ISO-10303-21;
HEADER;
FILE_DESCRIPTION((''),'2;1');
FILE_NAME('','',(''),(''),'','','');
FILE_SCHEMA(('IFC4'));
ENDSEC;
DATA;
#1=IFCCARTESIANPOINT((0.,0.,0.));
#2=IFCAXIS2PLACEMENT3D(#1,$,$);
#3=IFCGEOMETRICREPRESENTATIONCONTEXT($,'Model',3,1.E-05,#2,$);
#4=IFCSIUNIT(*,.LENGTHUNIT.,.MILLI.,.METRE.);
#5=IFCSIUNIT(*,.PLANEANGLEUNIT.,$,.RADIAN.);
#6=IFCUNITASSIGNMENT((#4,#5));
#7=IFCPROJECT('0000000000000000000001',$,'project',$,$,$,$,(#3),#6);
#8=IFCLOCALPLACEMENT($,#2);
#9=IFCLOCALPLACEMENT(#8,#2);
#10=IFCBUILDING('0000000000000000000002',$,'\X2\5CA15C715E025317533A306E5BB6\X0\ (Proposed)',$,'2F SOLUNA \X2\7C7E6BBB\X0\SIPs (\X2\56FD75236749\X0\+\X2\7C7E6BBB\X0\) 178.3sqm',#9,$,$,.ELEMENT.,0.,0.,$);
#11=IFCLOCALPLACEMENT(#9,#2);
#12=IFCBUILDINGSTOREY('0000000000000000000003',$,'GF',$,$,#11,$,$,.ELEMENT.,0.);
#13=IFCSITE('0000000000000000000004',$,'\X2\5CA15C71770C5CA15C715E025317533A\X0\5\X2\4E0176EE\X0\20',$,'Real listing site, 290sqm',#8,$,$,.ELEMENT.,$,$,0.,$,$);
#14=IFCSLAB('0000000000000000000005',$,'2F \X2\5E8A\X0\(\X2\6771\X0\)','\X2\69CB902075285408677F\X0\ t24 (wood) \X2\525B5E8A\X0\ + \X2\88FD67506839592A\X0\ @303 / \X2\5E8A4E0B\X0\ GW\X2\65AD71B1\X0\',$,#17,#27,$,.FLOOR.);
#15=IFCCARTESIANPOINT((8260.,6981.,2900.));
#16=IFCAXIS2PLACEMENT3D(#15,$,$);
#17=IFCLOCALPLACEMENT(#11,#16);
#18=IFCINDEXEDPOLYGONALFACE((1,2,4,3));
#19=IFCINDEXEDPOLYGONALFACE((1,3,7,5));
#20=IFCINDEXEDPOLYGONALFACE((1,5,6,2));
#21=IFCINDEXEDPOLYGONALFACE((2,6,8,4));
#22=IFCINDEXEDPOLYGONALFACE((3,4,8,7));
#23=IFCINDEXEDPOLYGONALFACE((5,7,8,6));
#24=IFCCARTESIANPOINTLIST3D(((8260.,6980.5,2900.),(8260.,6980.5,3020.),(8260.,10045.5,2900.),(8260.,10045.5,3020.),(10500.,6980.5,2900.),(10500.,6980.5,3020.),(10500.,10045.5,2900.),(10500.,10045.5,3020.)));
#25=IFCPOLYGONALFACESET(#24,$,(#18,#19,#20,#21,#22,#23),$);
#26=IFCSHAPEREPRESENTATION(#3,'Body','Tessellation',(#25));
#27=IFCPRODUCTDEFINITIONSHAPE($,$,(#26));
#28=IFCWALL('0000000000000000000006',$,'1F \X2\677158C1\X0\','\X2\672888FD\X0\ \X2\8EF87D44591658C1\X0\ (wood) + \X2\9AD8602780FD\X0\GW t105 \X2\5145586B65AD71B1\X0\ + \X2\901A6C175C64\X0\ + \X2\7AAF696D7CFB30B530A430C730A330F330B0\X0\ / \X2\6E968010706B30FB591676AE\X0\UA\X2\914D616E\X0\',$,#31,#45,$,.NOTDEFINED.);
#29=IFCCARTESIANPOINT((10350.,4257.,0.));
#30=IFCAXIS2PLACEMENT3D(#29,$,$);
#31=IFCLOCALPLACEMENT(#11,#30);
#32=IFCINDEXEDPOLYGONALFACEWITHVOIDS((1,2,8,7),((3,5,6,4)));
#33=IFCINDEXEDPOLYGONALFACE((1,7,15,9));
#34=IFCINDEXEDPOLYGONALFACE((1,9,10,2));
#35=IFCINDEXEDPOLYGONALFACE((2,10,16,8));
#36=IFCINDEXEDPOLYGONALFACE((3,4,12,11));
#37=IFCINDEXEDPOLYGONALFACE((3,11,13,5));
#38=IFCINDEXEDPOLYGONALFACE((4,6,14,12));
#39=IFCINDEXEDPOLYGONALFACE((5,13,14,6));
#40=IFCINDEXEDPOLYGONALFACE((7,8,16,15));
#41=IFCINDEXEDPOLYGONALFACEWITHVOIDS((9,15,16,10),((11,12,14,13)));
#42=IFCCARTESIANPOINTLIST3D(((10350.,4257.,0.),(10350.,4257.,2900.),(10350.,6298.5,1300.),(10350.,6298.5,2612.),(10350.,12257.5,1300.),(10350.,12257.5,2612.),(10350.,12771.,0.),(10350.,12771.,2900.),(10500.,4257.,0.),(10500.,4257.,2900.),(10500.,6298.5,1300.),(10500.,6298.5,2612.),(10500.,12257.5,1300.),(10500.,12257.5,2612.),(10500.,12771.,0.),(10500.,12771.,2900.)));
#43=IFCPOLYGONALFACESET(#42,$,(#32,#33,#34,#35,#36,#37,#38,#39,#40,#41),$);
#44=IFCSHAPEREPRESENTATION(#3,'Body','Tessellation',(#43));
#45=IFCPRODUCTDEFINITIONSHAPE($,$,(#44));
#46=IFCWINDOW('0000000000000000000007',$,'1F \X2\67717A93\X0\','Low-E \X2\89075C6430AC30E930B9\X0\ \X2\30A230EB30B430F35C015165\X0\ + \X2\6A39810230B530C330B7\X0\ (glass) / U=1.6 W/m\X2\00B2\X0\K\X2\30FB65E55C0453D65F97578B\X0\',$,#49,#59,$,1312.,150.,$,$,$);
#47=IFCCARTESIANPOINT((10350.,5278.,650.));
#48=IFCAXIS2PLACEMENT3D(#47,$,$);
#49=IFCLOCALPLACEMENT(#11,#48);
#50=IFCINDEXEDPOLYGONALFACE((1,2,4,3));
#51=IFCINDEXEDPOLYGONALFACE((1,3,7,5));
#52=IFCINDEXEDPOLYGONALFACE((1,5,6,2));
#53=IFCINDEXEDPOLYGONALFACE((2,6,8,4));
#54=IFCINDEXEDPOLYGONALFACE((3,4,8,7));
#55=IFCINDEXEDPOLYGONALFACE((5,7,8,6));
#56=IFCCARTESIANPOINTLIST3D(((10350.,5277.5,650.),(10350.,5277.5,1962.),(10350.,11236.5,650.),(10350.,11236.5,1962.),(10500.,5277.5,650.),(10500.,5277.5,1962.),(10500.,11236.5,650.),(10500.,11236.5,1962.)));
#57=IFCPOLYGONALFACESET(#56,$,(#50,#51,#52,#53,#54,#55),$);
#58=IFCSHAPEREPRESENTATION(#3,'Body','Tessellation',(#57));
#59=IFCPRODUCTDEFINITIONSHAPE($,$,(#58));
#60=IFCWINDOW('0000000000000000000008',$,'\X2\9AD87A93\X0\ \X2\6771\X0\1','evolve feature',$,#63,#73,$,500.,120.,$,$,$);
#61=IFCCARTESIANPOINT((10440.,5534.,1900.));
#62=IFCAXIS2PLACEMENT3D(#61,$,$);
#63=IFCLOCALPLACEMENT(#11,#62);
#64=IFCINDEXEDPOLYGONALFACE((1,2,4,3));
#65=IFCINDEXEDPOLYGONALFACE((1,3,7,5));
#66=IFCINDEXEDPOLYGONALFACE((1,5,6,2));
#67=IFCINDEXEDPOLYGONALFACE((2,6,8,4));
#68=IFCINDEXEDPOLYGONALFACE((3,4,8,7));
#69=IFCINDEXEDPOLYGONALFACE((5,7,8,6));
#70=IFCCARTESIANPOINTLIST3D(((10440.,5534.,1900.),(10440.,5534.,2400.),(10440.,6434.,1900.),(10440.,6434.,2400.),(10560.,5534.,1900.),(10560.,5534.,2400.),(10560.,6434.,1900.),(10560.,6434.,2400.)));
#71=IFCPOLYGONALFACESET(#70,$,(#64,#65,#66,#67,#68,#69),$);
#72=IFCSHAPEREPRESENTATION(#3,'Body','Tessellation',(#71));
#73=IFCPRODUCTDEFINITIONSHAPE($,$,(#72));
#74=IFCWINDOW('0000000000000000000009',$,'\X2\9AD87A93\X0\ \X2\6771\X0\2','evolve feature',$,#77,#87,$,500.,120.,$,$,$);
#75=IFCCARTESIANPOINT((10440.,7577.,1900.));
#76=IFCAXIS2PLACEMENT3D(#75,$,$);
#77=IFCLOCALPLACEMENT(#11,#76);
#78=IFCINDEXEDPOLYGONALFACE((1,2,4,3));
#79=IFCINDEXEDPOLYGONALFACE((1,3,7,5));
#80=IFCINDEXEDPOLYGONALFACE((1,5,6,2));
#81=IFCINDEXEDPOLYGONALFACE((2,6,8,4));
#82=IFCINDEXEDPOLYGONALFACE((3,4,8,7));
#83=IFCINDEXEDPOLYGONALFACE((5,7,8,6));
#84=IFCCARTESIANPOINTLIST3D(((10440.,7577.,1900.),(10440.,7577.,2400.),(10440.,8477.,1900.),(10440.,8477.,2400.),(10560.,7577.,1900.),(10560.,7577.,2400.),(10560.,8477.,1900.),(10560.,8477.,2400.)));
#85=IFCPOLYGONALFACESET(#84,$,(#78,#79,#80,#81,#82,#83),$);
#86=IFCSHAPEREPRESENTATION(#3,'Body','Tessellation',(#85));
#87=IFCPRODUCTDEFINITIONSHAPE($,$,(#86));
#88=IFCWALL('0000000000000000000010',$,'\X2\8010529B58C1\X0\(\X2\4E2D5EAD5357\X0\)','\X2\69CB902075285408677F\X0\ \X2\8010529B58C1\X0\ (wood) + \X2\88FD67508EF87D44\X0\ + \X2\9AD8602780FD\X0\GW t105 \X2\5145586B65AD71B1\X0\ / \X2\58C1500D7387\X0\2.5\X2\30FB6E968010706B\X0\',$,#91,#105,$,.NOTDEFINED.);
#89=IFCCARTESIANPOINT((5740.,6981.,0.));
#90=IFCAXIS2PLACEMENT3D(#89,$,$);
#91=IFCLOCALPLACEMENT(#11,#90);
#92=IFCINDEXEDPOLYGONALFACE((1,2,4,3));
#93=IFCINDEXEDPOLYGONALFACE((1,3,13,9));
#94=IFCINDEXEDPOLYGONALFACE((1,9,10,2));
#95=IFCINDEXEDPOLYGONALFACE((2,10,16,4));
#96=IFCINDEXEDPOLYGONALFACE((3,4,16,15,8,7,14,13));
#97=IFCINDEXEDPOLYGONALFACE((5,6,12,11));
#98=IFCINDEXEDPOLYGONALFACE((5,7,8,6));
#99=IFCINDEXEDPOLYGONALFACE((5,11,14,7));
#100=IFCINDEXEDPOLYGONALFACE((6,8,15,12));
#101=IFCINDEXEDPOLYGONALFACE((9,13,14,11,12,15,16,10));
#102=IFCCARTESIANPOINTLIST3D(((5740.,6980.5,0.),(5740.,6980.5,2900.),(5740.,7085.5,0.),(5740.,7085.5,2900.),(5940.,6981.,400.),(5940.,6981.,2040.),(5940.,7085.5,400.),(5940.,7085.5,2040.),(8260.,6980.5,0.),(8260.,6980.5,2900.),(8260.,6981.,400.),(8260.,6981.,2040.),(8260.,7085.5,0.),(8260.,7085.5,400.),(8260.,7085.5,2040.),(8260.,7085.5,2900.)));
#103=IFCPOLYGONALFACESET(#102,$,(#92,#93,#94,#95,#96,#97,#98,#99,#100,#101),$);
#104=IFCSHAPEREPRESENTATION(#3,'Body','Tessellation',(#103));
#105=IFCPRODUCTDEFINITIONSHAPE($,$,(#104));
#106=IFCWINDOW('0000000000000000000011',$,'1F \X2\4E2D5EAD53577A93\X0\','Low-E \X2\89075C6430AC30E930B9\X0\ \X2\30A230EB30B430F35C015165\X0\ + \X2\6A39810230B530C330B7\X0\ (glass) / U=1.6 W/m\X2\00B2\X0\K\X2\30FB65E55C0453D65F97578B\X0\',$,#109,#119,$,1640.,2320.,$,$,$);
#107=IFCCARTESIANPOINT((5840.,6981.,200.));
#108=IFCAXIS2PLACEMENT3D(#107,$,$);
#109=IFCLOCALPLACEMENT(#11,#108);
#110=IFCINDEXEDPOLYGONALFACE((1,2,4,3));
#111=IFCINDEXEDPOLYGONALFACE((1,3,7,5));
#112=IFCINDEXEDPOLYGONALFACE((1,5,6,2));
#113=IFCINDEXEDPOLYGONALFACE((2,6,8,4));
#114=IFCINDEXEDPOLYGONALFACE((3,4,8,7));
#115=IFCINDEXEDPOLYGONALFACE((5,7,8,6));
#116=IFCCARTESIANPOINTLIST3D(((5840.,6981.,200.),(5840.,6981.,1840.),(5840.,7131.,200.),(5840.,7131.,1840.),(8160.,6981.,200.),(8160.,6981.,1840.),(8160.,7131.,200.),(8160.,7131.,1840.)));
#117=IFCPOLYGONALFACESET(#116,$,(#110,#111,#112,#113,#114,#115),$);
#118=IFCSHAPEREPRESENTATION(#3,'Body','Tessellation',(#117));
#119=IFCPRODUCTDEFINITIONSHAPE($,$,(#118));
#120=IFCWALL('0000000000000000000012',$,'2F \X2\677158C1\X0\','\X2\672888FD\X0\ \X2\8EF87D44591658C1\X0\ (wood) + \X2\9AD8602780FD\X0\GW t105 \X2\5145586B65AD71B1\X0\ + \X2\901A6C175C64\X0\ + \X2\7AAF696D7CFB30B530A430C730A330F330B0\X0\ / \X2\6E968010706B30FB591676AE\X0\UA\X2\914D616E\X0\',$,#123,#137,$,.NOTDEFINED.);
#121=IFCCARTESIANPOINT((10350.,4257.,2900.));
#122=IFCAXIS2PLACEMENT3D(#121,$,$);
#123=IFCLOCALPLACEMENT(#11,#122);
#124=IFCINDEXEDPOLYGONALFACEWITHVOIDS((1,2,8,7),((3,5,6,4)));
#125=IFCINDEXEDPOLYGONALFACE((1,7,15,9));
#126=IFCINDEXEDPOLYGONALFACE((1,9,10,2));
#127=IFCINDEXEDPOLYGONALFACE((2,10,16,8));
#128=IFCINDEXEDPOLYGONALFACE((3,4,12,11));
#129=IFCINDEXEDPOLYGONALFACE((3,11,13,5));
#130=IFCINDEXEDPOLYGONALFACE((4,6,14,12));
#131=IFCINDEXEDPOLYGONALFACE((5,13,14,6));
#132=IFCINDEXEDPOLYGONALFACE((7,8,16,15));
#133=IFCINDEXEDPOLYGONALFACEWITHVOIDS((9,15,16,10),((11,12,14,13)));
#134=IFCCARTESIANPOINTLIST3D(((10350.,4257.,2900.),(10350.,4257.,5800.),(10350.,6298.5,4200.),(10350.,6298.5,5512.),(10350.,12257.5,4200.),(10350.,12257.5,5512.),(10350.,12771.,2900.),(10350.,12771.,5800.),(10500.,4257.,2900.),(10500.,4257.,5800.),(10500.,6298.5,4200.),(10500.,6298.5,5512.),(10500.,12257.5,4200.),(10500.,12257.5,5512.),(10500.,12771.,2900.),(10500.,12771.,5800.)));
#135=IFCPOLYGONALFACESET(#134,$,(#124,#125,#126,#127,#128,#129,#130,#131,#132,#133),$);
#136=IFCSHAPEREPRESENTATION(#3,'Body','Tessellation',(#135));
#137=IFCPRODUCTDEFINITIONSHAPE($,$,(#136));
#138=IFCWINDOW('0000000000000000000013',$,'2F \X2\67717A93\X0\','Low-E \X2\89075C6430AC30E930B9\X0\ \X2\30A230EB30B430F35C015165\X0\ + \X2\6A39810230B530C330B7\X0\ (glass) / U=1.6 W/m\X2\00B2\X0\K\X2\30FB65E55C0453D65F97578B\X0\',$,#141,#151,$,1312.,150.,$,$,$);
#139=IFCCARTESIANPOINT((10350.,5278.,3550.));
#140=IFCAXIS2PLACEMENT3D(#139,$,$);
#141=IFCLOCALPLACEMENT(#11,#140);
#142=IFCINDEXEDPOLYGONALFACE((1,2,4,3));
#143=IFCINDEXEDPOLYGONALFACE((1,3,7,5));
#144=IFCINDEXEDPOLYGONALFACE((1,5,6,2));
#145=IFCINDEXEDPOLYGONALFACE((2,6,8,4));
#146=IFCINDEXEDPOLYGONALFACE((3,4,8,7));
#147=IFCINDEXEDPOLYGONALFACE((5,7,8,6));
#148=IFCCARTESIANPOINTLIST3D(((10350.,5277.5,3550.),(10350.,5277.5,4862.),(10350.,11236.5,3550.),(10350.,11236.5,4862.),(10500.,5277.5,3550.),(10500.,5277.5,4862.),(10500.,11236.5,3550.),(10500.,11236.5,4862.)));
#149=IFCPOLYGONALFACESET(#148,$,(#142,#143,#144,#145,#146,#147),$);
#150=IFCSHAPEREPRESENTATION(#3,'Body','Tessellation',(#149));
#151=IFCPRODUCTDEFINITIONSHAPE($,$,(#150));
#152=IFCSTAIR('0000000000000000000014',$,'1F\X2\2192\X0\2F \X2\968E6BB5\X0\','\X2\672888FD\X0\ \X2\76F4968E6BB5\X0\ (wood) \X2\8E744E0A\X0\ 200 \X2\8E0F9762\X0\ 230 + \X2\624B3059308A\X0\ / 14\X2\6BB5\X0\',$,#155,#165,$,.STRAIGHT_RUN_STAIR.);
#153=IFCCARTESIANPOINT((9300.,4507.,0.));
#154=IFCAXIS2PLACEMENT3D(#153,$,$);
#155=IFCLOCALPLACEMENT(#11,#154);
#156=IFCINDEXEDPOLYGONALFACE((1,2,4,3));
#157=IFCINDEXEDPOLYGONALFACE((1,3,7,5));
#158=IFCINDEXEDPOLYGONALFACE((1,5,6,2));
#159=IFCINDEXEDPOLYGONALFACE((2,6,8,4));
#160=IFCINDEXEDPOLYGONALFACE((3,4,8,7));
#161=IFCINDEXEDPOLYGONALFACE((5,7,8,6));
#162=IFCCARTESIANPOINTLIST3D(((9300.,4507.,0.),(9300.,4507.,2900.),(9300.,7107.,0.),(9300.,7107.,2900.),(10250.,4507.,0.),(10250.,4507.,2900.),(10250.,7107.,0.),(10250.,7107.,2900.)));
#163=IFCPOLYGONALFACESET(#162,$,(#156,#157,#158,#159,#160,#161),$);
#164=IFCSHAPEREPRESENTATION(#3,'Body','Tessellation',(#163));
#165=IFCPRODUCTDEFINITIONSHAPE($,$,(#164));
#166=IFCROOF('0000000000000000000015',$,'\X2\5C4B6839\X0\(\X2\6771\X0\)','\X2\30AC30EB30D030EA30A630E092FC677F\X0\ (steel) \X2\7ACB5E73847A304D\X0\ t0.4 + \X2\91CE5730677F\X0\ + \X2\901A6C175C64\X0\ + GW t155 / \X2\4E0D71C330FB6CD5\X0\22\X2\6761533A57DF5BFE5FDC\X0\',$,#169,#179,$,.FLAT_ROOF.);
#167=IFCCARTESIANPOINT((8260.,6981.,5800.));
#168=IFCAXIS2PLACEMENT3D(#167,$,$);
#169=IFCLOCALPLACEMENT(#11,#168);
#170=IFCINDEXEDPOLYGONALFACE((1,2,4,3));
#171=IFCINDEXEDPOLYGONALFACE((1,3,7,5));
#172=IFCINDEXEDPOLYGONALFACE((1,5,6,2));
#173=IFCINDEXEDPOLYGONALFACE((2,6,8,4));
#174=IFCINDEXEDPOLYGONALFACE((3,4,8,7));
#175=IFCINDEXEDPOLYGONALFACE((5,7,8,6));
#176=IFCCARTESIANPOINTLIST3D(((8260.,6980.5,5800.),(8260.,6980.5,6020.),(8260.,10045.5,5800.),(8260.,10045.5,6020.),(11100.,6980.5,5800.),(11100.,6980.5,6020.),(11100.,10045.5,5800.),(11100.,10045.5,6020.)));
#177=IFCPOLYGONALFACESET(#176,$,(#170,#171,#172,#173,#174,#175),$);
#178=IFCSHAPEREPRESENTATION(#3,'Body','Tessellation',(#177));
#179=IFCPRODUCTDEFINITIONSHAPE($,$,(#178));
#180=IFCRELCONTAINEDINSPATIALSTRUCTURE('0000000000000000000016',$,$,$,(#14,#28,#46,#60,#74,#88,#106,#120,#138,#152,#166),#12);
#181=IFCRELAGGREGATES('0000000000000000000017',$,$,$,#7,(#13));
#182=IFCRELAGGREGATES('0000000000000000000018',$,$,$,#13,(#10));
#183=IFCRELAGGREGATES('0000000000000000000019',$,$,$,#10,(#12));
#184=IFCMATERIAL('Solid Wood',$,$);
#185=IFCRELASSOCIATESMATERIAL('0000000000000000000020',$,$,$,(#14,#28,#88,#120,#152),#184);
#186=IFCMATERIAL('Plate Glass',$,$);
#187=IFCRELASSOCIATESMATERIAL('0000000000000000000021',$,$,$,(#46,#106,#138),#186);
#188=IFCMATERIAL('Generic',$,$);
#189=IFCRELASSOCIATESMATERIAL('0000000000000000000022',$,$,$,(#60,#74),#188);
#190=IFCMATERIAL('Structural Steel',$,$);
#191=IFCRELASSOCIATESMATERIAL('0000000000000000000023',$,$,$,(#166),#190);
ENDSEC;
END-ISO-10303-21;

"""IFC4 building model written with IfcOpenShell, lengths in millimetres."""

from ifc_helpers import new_model, si_unit, frame, frame_2d, origin, place, context, project, spatial, rectangle, extrude, material, element, fill, save


model = new_model("IFC4")

# Units and contexts
model_context = context("Model", 3, precision=1e-05, world=origin())
ifc_project = project(units=[si_unit("LENGTHUNIT", "METRE", prefix="MILLI"), si_unit("PLANEANGLEUNIT", "RADIAN")], contexts=[model_context])

# Site, building, storey
site_placement = place(None, origin())
site = spatial("IfcSite", under=ifc_project, at=site_placement, Name="岡山県岡山市北区5丁目20", ObjectType="Real listing site, 290sqm", CompositionType="ELEMENT", RefElevation=0.0)
building_placement = place(site_placement, origin())
building = spatial("IfcBuilding", under=site, at=building_placement, Name="岡山市北区の家 (Proposed)", ObjectType="2F SOLUNA 籾殻SIPs (国産杉+籾殻) 178.3sqm", CompositionType="ELEMENT", ElevationOfRefHeight=0.0, ElevationOfTerrain=0.0)
storey_placement = place(building_placement, origin())
storey = spatial("IfcBuildingStorey", under=building, at=storey_placement, Name="GF", CompositionType="ELEMENT", Elevation=0.0)

# Slab
ifc_material_1 = material(Name="Solid Wood")
slab_1_placement = place(storey_placement, frame((8260.0, 6981.0, 2900.0)))
element("IfcSlab", 1, at=slab_1_placement, inside=storey, material=ifc_material_1, Name="2F 床(東)", Description="構造用合板 t24 (wood) 剛床 + 製材根太 @303 / 床下 GW断熱", PredefinedType="FLOOR", context=model_context, shape_type="SweptSolid", body=[
    extrude(rectangle(XDim=2240.0, YDim=3065.0, at=frame_2d((1120.0, 1532.0))), frame((8260.0, 6981.0, 2900.0)), (0.0, 0.0, 1.0), 120.0),
])

# Wall, openings, windows
wall_1_placement = place(storey_placement, frame((10350.0, 4257.0, 0.0)))
wall_1 = element("IfcWall", 2, at=wall_1_placement, inside=storey, material=ifc_material_1, Name="1F 東壁", Description="木製 軸組外壁 (wood) + 高性能GW t105 充填断熱 + 通気層 + 窯業系サイディング / 準耐火・外皮UA配慮", PredefinedType="NOTDEFINED", context=model_context, shape_type="SweptSolid", body=[
    extrude(rectangle(XDim=150.0, YDim=8514.0, at=frame_2d((75.0, 4257.0))), frame((10350.0, 4257.0, 0.0)), (0.0, 0.0, 1.0), 2900.0),
])
opening_1_placement = place(storey_placement, frame((10350.0, 5278.0, 650.0)))
opening_1 = element("IfcOpeningElement", 3, at=opening_1_placement, cuts=wall_1, PredefinedType="NOTDEFINED", context=model_context, shape_type="SweptSolid", body=[
    extrude(rectangle(XDim=150.0, YDim=5959.0, at=frame_2d((75.0, 2979.0))), frame((10350.0, 5278.0, 650.0)), (0.0, 0.0, 1.0), 1312.0),
])
opening_2_placement = place(storey_placement, frame((10440.0, 5534.0, 1900.0)))
opening_2 = element("IfcOpeningElement", 4, at=opening_2_placement, cuts=wall_1, PredefinedType="NOTDEFINED", context=model_context, shape_type="SweptSolid", body=[
    extrude(rectangle(XDim=120.0, YDim=900.0, at=frame_2d((60.0, 450.0))), frame((10440.0, 5534.0, 1900.0)), (0.0, 0.0, 1.0), 500.0),
])
opening_3_placement = place(storey_placement, frame((10440.0, 7577.0, 1900.0)))
opening_3 = element("IfcOpeningElement", 5, at=opening_3_placement, cuts=wall_1, PredefinedType="NOTDEFINED", context=model_context, shape_type="SweptSolid", body=[
    extrude(rectangle(XDim=120.0, YDim=900.0, at=frame_2d((60.0, 450.0))), frame((10440.0, 7577.0, 1900.0)), (0.0, 0.0, 1.0), 500.0),
])
ifc_material_2 = material(Name="Plate Glass")
window_1_placement = place(storey_placement, frame((10350.0, 5278.0, 650.0)))
window_1 = element("IfcWindow", 6, at=window_1_placement, inside=storey, material=ifc_material_2, Name="1F 東窓", Description="Low-E 複層ガラス アルゴン封入 + 樹脂サッシ (glass) / U=1.6 W/m²K・日射取得型", OverallHeight=1312.0, OverallWidth=150.0, context=model_context, shape_type="SweptSolid", body=[
    extrude(rectangle(XDim=150.0, YDim=5959.0, at=frame_2d((75.0, 2979.0))), frame((10350.0, 5278.0, 650.0)), (0.0, 0.0, 1.0), 1312.0),
])
fill(opening_1, window_1)
ifc_material_3 = material(Name="Generic")
window_2_placement = place(storey_placement, frame((10440.0, 5534.0, 1900.0)))
window_2 = element("IfcWindow", 7, at=window_2_placement, inside=storey, material=ifc_material_3, Name="高窓 東1", Description="evolve feature", OverallHeight=500.0, OverallWidth=120.0, context=model_context, shape_type="SweptSolid", body=[
    extrude(rectangle(XDim=120.0, YDim=900.0, at=frame_2d((60.0, 450.0))), frame((10440.0, 5534.0, 1900.0)), (0.0, 0.0, 1.0), 500.0),
])
fill(opening_2, window_2)
window_3_placement = place(storey_placement, frame((10440.0, 7577.0, 1900.0)))
window_3 = element("IfcWindow", 8, at=window_3_placement, inside=storey, material=ifc_material_3, Name="高窓 東2", Description="evolve feature", OverallHeight=500.0, OverallWidth=120.0, context=model_context, shape_type="SweptSolid", body=[
    extrude(rectangle(XDim=120.0, YDim=900.0, at=frame_2d((60.0, 450.0))), frame((10440.0, 7577.0, 1900.0)), (0.0, 0.0, 1.0), 500.0),
])
fill(opening_3, window_3)

# Wall, opening, window
wall_2_placement = place(storey_placement, frame((5740.0, 6981.0, 0.0)))
wall_2 = element("IfcWall", 9, at=wall_2_placement, inside=storey, material=ifc_material_1, Name="耐力壁(中庭南)", Description="構造用合板 耐力壁 (wood) + 製材軸組 + 高性能GW t105 充填断熱 / 壁倍率2.5・準耐火", PredefinedType="NOTDEFINED", context=model_context, shape_type="SweptSolid", body=[
    extrude(rectangle(XDim=2520.0, YDim=105.0, at=frame_2d((1260.0, 52.0))), frame((5740.0, 6981.0, 0.0)), (0.0, 0.0, 1.0), 2900.0),
])
opening_4_placement = place(storey_placement, frame((5840.0, 6981.0, 200.0)))
opening_4 = element("IfcOpeningElement", 10, at=opening_4_placement, cuts=wall_2, PredefinedType="NOTDEFINED", context=model_context, shape_type="SweptSolid", body=[
    extrude(rectangle(XDim=2320.0, YDim=150.0, at=frame_2d((1160.0, 75.0))), frame((5840.0, 6981.0, 200.0)), (0.0, 0.0, 1.0), 1640.0),
])
window_4_placement = place(storey_placement, frame((5840.0, 6981.0, 200.0)))
window_4 = element("IfcWindow", 11, at=window_4_placement, inside=storey, material=ifc_material_2, Name="1F 中庭南窓", Description="Low-E 複層ガラス アルゴン封入 + 樹脂サッシ (glass) / U=1.6 W/m²K・日射取得型", OverallHeight=1640.0, OverallWidth=2320.0, context=model_context, shape_type="SweptSolid", body=[
    extrude(rectangle(XDim=2320.0, YDim=150.0, at=frame_2d((1160.0, 75.0))), frame((5840.0, 6981.0, 200.0)), (0.0, 0.0, 1.0), 1640.0),
])
fill(opening_4, window_4)

# Wall, opening, window
wall_3_placement = place(storey_placement, frame((10350.0, 4257.0, 2900.0)))
wall_3 = element("IfcWall", 12, at=wall_3_placement, inside=storey, material=ifc_material_1, Name="2F 東壁", Description="木製 軸組外壁 (wood) + 高性能GW t105 充填断熱 + 通気層 + 窯業系サイディング / 準耐火・外皮UA配慮", PredefinedType="NOTDEFINED", context=model_context, shape_type="SweptSolid", body=[
    extrude(rectangle(XDim=150.0, YDim=8514.0, at=frame_2d((75.0, 4257.0))), frame((10350.0, 4257.0, 2900.0)), (0.0, 0.0, 1.0), 2900.0),
])
opening_5_placement = place(storey_placement, frame((10350.0, 5278.0, 3550.0)))
opening_5 = element("IfcOpeningElement", 13, at=opening_5_placement, cuts=wall_3, PredefinedType="NOTDEFINED", context=model_context, shape_type="SweptSolid", body=[
    extrude(rectangle(XDim=150.0, YDim=5959.0, at=frame_2d((75.0, 2979.0))), frame((10350.0, 5278.0, 3550.0)), (0.0, 0.0, 1.0), 1312.0),
])
window_5_placement = place(storey_placement, frame((10350.0, 5278.0, 3550.0)))
window_5 = element("IfcWindow", 14, at=window_5_placement, inside=storey, material=ifc_material_2, Name="2F 東窓", Description="Low-E 複層ガラス アルゴン封入 + 樹脂サッシ (glass) / U=1.6 W/m²K・日射取得型", OverallHeight=1312.0, OverallWidth=150.0, context=model_context, shape_type="SweptSolid", body=[
    extrude(rectangle(XDim=150.0, YDim=5959.0, at=frame_2d((75.0, 2979.0))), frame((10350.0, 5278.0, 3550.0)), (0.0, 0.0, 1.0), 1312.0),
])
fill(opening_5, window_5)

# Stair
stair_placement = place(storey_placement, frame((9300.0, 4507.0, 0.0)))
element("IfcStair", 15, at=stair_placement, inside=storey, material=ifc_material_1, Name="1F→2F 階段", Description="木製 直階段 (wood) 蹴上 200 踏面 230 + 手すり / 14段", PredefinedType="STRAIGHT_RUN_STAIR", context=model_context, shape_type="SweptSolid", body=[
    extrude(rectangle(XDim=950.0, YDim=2600.0, at=frame_2d((475.0, 1300.0))), frame((9300.0, 4507.0, 0.0)), (0.0, 0.0, 1.0), 2900.0),
])

# Roof
ifc_material_4 = material(Name="Structural Steel")
roof_placement = place(storey_placement, frame((8260.0, 6981.0, 5800.0)))
element("IfcRoof", 16, at=roof_placement, inside=storey, material=ifc_material_4, Name="屋根(東)", Description="ガルバリウム鋼板 (steel) 立平葺き t0.4 + 野地板 + 通気層 + GW t155 / 不燃・法22条区域対応", PredefinedType="FLAT_ROOF", context=model_context, shape_type="SweptSolid", body=[
    extrude(rectangle(XDim=2840.0, YDim=3065.0, at=frame_2d((1420.0, 1532.0))), frame((8260.0, 6981.0, 5800.0)), (0.0, 0.0, 1.0), 220.0),
])

save(model, "model.ifc")
